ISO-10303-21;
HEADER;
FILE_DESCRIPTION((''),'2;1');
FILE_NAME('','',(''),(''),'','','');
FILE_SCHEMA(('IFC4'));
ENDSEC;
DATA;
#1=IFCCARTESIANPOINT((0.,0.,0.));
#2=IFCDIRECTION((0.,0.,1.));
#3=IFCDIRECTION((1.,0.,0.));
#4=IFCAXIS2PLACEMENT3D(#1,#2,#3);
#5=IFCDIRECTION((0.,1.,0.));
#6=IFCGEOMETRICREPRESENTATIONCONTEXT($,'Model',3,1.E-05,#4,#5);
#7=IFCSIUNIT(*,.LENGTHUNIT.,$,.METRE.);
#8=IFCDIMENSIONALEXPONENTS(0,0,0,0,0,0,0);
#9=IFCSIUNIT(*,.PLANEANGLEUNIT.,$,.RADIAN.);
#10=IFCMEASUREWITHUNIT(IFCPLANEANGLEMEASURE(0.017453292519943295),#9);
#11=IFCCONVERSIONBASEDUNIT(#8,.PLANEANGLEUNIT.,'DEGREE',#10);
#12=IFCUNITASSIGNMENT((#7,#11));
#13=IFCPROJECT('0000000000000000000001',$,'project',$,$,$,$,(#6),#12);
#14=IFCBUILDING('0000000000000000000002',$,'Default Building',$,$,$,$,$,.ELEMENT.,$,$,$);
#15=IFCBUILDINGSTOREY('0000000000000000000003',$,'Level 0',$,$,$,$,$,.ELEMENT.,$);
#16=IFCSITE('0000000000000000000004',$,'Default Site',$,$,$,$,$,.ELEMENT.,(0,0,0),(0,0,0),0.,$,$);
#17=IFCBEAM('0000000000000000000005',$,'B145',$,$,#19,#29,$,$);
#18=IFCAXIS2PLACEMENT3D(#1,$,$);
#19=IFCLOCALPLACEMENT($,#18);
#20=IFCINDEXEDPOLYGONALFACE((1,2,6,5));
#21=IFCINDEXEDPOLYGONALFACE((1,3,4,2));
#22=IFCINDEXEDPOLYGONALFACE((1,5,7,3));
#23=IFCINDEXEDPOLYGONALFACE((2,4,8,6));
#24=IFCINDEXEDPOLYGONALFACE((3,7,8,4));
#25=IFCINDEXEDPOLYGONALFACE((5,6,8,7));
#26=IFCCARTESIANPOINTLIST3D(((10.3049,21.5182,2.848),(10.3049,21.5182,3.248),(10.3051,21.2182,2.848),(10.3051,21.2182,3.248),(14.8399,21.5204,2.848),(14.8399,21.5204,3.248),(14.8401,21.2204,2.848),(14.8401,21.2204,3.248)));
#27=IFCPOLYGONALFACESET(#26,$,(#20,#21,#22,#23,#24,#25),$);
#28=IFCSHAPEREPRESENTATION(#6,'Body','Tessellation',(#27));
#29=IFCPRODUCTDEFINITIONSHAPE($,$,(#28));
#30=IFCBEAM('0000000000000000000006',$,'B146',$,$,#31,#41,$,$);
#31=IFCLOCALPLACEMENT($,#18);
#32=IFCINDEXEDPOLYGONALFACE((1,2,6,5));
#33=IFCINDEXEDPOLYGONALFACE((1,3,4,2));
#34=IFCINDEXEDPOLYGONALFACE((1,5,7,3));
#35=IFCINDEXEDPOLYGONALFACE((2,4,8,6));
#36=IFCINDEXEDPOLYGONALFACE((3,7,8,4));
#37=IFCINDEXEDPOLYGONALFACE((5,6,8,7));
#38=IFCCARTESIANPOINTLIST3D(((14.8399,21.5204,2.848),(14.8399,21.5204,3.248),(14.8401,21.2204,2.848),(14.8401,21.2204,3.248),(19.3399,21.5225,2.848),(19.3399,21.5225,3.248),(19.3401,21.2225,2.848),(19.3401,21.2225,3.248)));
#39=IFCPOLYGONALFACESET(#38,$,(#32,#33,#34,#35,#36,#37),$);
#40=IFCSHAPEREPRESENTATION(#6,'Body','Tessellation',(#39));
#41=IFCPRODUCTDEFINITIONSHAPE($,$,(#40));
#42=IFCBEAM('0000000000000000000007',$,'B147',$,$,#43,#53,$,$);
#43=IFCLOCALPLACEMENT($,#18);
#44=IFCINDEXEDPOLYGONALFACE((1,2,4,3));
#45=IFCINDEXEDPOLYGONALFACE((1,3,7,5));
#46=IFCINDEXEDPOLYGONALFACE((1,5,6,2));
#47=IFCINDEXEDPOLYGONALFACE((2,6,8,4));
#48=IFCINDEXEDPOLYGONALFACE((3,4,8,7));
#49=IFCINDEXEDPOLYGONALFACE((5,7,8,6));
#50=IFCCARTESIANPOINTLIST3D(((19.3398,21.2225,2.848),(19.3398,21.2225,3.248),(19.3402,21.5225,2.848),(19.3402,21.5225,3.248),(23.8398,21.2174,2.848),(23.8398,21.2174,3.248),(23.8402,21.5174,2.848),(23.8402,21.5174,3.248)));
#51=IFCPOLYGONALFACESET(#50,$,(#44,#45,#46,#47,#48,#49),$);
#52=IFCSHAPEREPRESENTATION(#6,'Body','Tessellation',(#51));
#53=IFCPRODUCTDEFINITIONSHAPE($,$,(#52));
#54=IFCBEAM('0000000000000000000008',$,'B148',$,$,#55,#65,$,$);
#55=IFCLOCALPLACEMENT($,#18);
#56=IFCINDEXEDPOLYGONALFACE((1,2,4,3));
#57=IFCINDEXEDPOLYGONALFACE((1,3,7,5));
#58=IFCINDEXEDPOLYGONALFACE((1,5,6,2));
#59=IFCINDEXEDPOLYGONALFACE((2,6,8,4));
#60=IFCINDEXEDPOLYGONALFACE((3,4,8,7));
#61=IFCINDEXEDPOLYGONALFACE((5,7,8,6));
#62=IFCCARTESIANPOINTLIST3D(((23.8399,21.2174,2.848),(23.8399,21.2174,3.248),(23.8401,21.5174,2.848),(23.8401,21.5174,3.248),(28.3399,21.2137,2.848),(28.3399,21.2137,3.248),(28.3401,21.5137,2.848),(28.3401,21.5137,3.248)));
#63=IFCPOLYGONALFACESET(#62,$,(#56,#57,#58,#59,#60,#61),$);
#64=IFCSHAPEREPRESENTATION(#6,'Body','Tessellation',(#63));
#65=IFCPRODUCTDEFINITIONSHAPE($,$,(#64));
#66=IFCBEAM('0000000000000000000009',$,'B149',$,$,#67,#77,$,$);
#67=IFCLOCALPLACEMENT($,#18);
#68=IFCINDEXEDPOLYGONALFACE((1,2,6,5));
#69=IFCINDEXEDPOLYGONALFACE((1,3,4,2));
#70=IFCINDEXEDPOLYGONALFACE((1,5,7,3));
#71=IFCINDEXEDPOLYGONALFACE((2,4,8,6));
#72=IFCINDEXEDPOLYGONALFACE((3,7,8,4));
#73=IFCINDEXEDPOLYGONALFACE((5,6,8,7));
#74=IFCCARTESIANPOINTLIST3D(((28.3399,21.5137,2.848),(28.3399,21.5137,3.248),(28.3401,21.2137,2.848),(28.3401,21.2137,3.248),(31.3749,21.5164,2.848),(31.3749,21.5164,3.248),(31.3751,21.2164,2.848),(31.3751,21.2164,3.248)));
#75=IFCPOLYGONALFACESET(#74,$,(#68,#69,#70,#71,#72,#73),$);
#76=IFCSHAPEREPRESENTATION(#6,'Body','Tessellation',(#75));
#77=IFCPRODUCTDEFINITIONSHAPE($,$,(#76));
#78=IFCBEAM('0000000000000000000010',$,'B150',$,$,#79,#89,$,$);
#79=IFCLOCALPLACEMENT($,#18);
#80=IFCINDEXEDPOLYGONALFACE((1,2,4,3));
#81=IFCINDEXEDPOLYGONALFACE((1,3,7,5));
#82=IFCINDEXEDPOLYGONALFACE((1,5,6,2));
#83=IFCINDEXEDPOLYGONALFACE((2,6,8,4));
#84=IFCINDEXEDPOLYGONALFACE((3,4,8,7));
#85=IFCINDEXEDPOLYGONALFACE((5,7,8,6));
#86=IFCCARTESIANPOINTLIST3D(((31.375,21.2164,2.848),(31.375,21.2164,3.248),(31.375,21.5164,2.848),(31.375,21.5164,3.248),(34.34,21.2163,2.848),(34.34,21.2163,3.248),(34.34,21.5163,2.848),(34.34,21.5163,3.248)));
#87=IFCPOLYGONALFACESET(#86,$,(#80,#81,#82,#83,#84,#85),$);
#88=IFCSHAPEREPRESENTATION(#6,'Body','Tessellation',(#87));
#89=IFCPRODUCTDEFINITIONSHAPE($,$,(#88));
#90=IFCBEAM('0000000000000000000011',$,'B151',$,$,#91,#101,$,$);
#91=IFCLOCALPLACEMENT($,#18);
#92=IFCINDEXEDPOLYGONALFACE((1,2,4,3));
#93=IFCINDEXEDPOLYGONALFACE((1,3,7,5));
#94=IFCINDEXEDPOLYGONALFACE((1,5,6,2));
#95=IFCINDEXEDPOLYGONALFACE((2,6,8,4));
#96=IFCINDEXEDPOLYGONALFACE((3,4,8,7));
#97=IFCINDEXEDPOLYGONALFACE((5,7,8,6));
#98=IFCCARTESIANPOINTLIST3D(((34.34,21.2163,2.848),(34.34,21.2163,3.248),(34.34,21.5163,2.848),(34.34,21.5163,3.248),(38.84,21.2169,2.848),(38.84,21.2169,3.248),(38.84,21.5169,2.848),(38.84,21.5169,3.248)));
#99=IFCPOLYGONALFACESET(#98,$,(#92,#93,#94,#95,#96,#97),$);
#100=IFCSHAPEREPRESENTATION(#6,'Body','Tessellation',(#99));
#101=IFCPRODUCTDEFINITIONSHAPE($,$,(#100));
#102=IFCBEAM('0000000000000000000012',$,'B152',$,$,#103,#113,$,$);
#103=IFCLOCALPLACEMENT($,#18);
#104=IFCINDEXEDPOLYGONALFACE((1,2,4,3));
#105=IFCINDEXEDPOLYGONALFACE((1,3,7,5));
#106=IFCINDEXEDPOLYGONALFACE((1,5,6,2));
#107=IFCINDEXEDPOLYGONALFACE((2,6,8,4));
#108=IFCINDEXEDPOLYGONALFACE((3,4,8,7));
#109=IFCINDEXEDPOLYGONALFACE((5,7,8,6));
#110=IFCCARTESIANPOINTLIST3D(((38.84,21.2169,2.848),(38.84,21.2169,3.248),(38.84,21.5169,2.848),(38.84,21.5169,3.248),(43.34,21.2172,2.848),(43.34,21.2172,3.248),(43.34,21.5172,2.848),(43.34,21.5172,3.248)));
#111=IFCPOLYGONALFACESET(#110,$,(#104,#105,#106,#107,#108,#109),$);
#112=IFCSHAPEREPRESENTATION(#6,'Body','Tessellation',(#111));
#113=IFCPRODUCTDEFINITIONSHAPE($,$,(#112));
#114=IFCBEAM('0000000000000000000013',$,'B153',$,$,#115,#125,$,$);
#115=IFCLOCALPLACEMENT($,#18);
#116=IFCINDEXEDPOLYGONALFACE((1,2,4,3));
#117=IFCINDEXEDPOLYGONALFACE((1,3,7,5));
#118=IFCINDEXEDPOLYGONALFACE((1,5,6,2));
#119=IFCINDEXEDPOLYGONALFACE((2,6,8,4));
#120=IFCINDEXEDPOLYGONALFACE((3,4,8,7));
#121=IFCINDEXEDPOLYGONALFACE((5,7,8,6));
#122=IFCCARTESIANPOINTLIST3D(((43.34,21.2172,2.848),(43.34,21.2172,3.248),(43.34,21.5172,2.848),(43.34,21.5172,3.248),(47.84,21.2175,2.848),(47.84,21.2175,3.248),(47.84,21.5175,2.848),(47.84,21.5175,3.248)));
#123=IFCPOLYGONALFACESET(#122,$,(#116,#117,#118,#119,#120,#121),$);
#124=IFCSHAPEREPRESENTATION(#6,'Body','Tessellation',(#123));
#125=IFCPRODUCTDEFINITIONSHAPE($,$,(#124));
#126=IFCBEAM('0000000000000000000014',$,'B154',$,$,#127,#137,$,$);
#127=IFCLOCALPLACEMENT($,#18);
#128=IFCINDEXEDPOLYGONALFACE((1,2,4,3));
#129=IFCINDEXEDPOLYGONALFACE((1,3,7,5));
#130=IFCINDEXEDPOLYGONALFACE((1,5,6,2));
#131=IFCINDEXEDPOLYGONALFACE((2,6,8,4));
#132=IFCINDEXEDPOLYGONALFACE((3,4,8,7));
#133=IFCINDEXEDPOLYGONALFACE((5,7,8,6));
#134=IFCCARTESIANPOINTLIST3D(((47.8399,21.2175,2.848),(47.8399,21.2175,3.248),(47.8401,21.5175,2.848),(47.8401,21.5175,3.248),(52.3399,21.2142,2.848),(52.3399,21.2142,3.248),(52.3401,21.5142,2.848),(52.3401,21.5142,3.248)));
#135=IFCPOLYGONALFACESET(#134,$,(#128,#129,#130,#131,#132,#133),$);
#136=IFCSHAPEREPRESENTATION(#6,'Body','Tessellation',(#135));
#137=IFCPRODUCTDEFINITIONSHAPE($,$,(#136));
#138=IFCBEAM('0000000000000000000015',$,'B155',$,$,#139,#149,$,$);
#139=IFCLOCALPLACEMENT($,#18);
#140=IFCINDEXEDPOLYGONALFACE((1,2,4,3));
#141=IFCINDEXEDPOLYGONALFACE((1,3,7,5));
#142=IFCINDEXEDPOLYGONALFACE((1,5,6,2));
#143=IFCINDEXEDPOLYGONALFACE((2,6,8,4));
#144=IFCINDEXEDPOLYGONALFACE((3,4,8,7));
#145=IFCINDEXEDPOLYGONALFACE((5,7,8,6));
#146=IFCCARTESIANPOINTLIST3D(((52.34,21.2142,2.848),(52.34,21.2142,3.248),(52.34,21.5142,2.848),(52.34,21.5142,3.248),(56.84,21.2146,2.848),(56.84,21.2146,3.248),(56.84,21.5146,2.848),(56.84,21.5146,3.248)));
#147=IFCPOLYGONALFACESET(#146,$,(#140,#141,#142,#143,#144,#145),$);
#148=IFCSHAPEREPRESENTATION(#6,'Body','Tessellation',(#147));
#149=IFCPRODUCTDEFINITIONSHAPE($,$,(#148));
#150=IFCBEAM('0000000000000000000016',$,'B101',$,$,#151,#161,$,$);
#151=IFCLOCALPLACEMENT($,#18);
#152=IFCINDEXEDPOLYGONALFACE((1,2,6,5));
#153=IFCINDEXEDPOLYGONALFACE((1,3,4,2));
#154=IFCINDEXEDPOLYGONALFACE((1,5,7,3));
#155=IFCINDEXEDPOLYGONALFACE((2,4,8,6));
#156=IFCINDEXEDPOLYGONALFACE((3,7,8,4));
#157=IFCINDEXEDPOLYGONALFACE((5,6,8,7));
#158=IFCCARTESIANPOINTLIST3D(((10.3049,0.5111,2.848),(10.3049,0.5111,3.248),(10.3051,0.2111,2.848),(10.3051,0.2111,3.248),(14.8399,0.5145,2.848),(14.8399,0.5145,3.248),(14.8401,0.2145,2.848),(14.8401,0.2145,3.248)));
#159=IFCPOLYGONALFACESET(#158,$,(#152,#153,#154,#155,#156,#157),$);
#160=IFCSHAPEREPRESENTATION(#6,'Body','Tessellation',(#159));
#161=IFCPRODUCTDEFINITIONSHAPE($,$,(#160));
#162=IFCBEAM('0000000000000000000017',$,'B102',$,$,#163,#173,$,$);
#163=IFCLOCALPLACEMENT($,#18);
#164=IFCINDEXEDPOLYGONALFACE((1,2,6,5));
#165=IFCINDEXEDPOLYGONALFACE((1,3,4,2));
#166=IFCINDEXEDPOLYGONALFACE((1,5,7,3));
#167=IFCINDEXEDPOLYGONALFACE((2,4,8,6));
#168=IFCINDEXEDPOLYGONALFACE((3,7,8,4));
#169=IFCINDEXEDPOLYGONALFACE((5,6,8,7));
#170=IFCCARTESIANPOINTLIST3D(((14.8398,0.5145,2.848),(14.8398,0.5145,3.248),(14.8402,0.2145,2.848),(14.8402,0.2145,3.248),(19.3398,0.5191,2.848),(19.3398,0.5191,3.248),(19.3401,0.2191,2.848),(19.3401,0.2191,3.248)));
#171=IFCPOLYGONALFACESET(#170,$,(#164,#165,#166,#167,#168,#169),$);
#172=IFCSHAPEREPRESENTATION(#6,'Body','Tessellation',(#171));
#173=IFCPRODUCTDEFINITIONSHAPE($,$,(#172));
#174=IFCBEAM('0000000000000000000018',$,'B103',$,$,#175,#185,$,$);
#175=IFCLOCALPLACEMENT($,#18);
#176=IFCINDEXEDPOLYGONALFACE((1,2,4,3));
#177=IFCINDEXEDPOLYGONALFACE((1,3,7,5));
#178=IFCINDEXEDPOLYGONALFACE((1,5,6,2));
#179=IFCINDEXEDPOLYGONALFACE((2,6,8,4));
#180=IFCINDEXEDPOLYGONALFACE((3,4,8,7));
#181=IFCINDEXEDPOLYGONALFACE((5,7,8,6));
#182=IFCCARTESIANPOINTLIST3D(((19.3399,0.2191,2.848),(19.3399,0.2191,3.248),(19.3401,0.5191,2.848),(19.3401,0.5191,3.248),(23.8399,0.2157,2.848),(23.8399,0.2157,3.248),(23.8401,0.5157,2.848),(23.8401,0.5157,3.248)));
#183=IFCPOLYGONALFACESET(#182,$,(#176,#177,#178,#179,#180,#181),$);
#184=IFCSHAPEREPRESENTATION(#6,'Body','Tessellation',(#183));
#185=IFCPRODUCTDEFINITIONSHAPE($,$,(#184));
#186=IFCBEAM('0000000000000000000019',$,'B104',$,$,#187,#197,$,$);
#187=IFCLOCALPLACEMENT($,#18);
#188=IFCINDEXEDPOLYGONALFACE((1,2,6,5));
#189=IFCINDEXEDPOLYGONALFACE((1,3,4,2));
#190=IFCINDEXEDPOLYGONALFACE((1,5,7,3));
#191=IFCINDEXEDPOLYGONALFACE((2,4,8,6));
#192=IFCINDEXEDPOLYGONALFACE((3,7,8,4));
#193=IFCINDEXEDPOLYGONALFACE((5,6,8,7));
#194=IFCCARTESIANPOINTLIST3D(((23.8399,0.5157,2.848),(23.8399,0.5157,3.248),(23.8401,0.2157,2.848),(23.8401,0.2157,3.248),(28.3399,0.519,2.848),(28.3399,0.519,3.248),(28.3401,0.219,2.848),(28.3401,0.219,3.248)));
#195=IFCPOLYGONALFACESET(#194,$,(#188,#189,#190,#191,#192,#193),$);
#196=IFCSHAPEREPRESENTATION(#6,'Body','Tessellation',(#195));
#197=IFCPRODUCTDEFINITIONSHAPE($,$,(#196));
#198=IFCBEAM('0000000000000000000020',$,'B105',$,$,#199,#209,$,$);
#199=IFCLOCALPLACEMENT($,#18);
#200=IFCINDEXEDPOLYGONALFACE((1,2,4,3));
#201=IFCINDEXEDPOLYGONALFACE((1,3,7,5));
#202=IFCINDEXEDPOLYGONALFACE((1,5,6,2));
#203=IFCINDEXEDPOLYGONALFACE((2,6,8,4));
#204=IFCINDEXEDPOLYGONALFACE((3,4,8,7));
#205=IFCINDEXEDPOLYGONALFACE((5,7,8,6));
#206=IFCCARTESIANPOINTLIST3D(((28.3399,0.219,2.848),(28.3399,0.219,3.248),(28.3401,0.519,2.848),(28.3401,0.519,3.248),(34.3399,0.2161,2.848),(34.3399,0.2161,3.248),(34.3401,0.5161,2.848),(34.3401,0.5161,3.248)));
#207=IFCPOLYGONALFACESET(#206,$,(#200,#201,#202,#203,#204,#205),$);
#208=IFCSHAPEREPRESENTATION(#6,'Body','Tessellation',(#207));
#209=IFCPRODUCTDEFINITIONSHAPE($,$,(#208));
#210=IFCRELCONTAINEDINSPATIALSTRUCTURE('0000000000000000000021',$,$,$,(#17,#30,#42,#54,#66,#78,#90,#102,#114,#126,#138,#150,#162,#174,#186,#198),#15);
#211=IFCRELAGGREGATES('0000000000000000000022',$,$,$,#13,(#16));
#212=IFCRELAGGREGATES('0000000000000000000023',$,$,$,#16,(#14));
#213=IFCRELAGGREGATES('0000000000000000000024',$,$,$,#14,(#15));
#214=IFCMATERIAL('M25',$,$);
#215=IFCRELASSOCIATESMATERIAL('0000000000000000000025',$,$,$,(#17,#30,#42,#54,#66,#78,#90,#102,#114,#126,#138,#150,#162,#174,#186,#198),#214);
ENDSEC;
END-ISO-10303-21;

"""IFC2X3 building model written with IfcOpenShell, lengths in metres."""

from ifc_helpers import new_model, entity, si_unit, converted_unit, direction, frame, frame_2d, origin_with_axes, place, context, project, spatial, rectangle, extrude, material, element, save


model = new_model("IFC2X3")

# Units and contexts
model_context = context("Model", 3, precision=1e-05, world=origin_with_axes(), true_north=direction((0.0, 1.0, 0.0)))
ifc_project = project(units=[si_unit("LENGTHUNIT", "METRE"), converted_unit("PLANEANGLEUNIT", "DEGREE", entity("IfcPlaneAngleMeasure", 0.017453292519943295), si_unit("PLANEANGLEUNIT", "RADIAN"), dimensions=[0, 0, 0, 0, 0, 0, 0])], contexts=[model_context])

# Site, building, storey
site = spatial("IfcSite", under=ifc_project, Name="Default Site", CompositionType="ELEMENT", RefLatitude=(0, 0, 0), RefLongitude=(0, 0, 0), RefElevation=0.0)
building = spatial("IfcBuilding", under=site, Name="Default Building", CompositionType="ELEMENT")
storey = spatial("IfcBuildingStorey", under=building, Name="Level 0", CompositionType="ELEMENT")

# Beams
ifc_material = material(Name="M25")
placement = place(None, origin_with_axes())
element("IfcBeam", 1, at=placement, inside=storey, material=ifc_material, Name="B145", context=model_context, shape_type="SweptSolid", body=[
    extrude(rectangle(XDim=0.3, YDim=0.4, at=frame_2d((0.0, 0.0), x_axis=(0.0, 1.0, 0.0))), frame((10.305, 21.3682, 3.048), z_axis=(1.0, 0.000476, 0.0), x_axis=(0.0, 0.0, -1.0)), (0.0, 0.0, 1.0), 4.535),
])
element("IfcBeam", 2, at=placement, inside=storey, material=ifc_material, Name="B146", context=model_context, shape_type="SweptSolid", body=[
    extrude(rectangle(XDim=0.3, YDim=0.4, at=frame_2d((0.0, 0.0), x_axis=(0.0, 1.0, 0.0))), frame((14.84, 21.3704, 3.048), z_axis=(1.0, 0.000471, 0.0), x_axis=(0.0, 0.0, -1.0)), (0.0, 0.0, 1.0), 4.5),
])
element("IfcBeam", 3, at=placement, inside=storey, material=ifc_material, Name="B147", context=model_context, shape_type="SweptSolid", body=[
    extrude(rectangle(XDim=0.3, YDim=0.4, at=frame_2d((0.0, 0.0), x_axis=(0.0, 1.0, 0.0))), frame((19.34, 21.3725, 3.048), z_axis=(0.999999, -0.001141, 0.0), x_axis=(0.0, 0.0, -1.0)), (0.0, 0.0, 1.0), 4.5),
])
element("IfcBeam", 4, at=placement, inside=storey, material=ifc_material, Name="B148", context=model_context, shape_type="SweptSolid", body=[
    extrude(rectangle(XDim=0.3, YDim=0.4, at=frame_2d((0.0, 0.0), x_axis=(0.0, 1.0, 0.0))), frame((23.84, 21.3674, 3.048), z_axis=(1.0, -0.000812, 0.0), x_axis=(0.0, 0.0, -1.0)), (0.0, 0.0, 1.0), 4.5),
])
element("IfcBeam", 5, at=placement, inside=storey, material=ifc_material, Name="B149", context=model_context, shape_type="SweptSolid", body=[
    extrude(rectangle(XDim=0.3, YDim=0.4, at=frame_2d((0.0, 0.0), x_axis=(0.0, 1.0, 0.0))), frame((28.34, 21.3637, 3.048), z_axis=(1.0, 0.000883, 0.0), x_axis=(0.0, 0.0, -1.0)), (0.0, 0.0, 1.0), 3.035),
])
element("IfcBeam", 6, at=placement, inside=storey, material=ifc_material, Name="B150", context=model_context, shape_type="SweptSolid", body=[
    extrude(rectangle(XDim=0.3, YDim=0.4, at=frame_2d((0.0, 0.0), x_axis=(0.0, 1.0, 0.0))), frame((31.375, 21.3664, 3.048), z_axis=(1.0, -0.000016, 0.0), x_axis=(0.0, 0.0, -1.0)), (0.0, 0.0, 1.0), 2.965),
])
element("IfcBeam", 7, at=placement, inside=storey, material=ifc_material, Name="B151", context=model_context, shape_type="SweptSolid", body=[
    extrude(rectangle(XDim=0.3, YDim=0.4, at=frame_2d((0.0, 0.0), x_axis=(0.0, 1.0, 0.0))), frame((34.34, 21.3663, 3.048), z_axis=(1.0, 0.000136, 0.0), x_axis=(0.0, 0.0, -1.0)), (0.0, 0.0, 1.0), 4.5),
])
element("IfcBeam", 8, at=placement, inside=storey, material=ifc_material, Name="B152", context=model_context, shape_type="SweptSolid", body=[
    extrude(rectangle(XDim=0.3, YDim=0.4, at=frame_2d((0.0, 0.0), x_axis=(0.0, 1.0, 0.0))), frame((38.84, 21.3669, 3.048), z_axis=(1.0, 0.00005, 0.0), x_axis=(0.0, 0.0, -1.0)), (0.0, 0.0, 1.0), 4.5),
])
element("IfcBeam", 9, at=placement, inside=storey, material=ifc_material, Name="B153", context=model_context, shape_type="SweptSolid", body=[
    extrude(rectangle(XDim=0.3, YDim=0.4, at=frame_2d((0.0, 0.0), x_axis=(0.0, 1.0, 0.0))), frame((43.34, 21.3672, 3.048), z_axis=(1.0, 0.000075, 0.0), x_axis=(0.0, 0.0, -1.0)), (0.0, 0.0, 1.0), 4.5),
])
element("IfcBeam", 10, at=placement, inside=storey, material=ifc_material, Name="B154", context=model_context, shape_type="SweptSolid", body=[
    extrude(rectangle(XDim=0.3, YDim=0.4, at=frame_2d((0.0, 0.0), x_axis=(0.0, 1.0, 0.0))), frame((47.84, 21.3675, 3.048), z_axis=(1.0, -0.000744, 0.0), x_axis=(0.0, 0.0, -1.0)), (0.0, 0.0, 1.0), 4.5),
])
element("IfcBeam", 11, at=placement, inside=storey, material=ifc_material, Name="B155", context=model_context, shape_type="SweptSolid", body=[
    extrude(rectangle(XDim=0.3, YDim=0.4, at=frame_2d((0.0, 0.0), x_axis=(0.0, 1.0, 0.0))), frame((52.34, 21.3642, 3.048), z_axis=(1.0, 0.000102, 0.0), x_axis=(0.0, 0.0, -1.0)), (0.0, 0.0, 1.0), 4.5),
])
element("IfcBeam", 12, at=placement, inside=storey, material=ifc_material, Name="B101", context=model_context, shape_type="SweptSolid", body=[
    extrude(rectangle(XDim=0.3, YDim=0.4, at=frame_2d((0.0, 0.0), x_axis=(0.0, 1.0, 0.0))), frame((10.305, 0.3611, 3.048), z_axis=(1.0, 0.000762, 0.0), x_axis=(0.0, 0.0, -1.0)), (0.0, 0.0, 1.0), 4.535),
])
element("IfcBeam", 13, at=placement, inside=storey, material=ifc_material, Name="B102", context=model_context, shape_type="SweptSolid", body=[
    extrude(rectangle(XDim=0.3, YDim=0.4, at=frame_2d((0.0, 0.0), x_axis=(0.0, 1.0, 0.0))), frame((14.84, 0.3645, 3.048), z_axis=(0.999999, 0.00101, 0.0), x_axis=(0.0, 0.0, -1.0)), (0.0, 0.0, 1.0), 4.5),
])
element("IfcBeam", 14, at=placement, inside=storey, material=ifc_material, Name="B103", context=model_context, shape_type="SweptSolid", body=[
    extrude(rectangle(XDim=0.3, YDim=0.4, at=frame_2d((0.0, 0.0), x_axis=(0.0, 1.0, 0.0))), frame((19.34, 0.3691, 3.048), z_axis=(1.0, -0.000757, 0.0), x_axis=(0.0, 0.0, -1.0)), (0.0, 0.0, 1.0), 4.5),
])
element("IfcBeam", 15, at=placement, inside=storey, material=ifc_material, Name="B104", context=model_context, shape_type="SweptSolid", body=[
    extrude(rectangle(XDim=0.3, YDim=0.4, at=frame_2d((0.0, 0.0), x_axis=(0.0, 1.0, 0.0))), frame((23.84, 0.3657, 3.048), z_axis=(1.0, 0.00075, 0.0), x_axis=(0.0, 0.0, -1.0)), (0.0, 0.0, 1.0), 4.5),
])
element("IfcBeam", 16, at=placement, inside=storey, material=ifc_material, Name="B105", context=model_context, shape_type="SweptSolid", body=[
    extrude(rectangle(XDim=0.3, YDim=0.4, at=frame_2d((0.0, 0.0), x_axis=(0.0, 1.0, 0.0))), frame((28.34, 0.369, 3.048), z_axis=(1.0, -0.000487, 0.0), x_axis=(0.0, 0.0, -1.0)), (0.0, 0.0, 1.0), 6.0),
])

save(model, "model.ifc")
